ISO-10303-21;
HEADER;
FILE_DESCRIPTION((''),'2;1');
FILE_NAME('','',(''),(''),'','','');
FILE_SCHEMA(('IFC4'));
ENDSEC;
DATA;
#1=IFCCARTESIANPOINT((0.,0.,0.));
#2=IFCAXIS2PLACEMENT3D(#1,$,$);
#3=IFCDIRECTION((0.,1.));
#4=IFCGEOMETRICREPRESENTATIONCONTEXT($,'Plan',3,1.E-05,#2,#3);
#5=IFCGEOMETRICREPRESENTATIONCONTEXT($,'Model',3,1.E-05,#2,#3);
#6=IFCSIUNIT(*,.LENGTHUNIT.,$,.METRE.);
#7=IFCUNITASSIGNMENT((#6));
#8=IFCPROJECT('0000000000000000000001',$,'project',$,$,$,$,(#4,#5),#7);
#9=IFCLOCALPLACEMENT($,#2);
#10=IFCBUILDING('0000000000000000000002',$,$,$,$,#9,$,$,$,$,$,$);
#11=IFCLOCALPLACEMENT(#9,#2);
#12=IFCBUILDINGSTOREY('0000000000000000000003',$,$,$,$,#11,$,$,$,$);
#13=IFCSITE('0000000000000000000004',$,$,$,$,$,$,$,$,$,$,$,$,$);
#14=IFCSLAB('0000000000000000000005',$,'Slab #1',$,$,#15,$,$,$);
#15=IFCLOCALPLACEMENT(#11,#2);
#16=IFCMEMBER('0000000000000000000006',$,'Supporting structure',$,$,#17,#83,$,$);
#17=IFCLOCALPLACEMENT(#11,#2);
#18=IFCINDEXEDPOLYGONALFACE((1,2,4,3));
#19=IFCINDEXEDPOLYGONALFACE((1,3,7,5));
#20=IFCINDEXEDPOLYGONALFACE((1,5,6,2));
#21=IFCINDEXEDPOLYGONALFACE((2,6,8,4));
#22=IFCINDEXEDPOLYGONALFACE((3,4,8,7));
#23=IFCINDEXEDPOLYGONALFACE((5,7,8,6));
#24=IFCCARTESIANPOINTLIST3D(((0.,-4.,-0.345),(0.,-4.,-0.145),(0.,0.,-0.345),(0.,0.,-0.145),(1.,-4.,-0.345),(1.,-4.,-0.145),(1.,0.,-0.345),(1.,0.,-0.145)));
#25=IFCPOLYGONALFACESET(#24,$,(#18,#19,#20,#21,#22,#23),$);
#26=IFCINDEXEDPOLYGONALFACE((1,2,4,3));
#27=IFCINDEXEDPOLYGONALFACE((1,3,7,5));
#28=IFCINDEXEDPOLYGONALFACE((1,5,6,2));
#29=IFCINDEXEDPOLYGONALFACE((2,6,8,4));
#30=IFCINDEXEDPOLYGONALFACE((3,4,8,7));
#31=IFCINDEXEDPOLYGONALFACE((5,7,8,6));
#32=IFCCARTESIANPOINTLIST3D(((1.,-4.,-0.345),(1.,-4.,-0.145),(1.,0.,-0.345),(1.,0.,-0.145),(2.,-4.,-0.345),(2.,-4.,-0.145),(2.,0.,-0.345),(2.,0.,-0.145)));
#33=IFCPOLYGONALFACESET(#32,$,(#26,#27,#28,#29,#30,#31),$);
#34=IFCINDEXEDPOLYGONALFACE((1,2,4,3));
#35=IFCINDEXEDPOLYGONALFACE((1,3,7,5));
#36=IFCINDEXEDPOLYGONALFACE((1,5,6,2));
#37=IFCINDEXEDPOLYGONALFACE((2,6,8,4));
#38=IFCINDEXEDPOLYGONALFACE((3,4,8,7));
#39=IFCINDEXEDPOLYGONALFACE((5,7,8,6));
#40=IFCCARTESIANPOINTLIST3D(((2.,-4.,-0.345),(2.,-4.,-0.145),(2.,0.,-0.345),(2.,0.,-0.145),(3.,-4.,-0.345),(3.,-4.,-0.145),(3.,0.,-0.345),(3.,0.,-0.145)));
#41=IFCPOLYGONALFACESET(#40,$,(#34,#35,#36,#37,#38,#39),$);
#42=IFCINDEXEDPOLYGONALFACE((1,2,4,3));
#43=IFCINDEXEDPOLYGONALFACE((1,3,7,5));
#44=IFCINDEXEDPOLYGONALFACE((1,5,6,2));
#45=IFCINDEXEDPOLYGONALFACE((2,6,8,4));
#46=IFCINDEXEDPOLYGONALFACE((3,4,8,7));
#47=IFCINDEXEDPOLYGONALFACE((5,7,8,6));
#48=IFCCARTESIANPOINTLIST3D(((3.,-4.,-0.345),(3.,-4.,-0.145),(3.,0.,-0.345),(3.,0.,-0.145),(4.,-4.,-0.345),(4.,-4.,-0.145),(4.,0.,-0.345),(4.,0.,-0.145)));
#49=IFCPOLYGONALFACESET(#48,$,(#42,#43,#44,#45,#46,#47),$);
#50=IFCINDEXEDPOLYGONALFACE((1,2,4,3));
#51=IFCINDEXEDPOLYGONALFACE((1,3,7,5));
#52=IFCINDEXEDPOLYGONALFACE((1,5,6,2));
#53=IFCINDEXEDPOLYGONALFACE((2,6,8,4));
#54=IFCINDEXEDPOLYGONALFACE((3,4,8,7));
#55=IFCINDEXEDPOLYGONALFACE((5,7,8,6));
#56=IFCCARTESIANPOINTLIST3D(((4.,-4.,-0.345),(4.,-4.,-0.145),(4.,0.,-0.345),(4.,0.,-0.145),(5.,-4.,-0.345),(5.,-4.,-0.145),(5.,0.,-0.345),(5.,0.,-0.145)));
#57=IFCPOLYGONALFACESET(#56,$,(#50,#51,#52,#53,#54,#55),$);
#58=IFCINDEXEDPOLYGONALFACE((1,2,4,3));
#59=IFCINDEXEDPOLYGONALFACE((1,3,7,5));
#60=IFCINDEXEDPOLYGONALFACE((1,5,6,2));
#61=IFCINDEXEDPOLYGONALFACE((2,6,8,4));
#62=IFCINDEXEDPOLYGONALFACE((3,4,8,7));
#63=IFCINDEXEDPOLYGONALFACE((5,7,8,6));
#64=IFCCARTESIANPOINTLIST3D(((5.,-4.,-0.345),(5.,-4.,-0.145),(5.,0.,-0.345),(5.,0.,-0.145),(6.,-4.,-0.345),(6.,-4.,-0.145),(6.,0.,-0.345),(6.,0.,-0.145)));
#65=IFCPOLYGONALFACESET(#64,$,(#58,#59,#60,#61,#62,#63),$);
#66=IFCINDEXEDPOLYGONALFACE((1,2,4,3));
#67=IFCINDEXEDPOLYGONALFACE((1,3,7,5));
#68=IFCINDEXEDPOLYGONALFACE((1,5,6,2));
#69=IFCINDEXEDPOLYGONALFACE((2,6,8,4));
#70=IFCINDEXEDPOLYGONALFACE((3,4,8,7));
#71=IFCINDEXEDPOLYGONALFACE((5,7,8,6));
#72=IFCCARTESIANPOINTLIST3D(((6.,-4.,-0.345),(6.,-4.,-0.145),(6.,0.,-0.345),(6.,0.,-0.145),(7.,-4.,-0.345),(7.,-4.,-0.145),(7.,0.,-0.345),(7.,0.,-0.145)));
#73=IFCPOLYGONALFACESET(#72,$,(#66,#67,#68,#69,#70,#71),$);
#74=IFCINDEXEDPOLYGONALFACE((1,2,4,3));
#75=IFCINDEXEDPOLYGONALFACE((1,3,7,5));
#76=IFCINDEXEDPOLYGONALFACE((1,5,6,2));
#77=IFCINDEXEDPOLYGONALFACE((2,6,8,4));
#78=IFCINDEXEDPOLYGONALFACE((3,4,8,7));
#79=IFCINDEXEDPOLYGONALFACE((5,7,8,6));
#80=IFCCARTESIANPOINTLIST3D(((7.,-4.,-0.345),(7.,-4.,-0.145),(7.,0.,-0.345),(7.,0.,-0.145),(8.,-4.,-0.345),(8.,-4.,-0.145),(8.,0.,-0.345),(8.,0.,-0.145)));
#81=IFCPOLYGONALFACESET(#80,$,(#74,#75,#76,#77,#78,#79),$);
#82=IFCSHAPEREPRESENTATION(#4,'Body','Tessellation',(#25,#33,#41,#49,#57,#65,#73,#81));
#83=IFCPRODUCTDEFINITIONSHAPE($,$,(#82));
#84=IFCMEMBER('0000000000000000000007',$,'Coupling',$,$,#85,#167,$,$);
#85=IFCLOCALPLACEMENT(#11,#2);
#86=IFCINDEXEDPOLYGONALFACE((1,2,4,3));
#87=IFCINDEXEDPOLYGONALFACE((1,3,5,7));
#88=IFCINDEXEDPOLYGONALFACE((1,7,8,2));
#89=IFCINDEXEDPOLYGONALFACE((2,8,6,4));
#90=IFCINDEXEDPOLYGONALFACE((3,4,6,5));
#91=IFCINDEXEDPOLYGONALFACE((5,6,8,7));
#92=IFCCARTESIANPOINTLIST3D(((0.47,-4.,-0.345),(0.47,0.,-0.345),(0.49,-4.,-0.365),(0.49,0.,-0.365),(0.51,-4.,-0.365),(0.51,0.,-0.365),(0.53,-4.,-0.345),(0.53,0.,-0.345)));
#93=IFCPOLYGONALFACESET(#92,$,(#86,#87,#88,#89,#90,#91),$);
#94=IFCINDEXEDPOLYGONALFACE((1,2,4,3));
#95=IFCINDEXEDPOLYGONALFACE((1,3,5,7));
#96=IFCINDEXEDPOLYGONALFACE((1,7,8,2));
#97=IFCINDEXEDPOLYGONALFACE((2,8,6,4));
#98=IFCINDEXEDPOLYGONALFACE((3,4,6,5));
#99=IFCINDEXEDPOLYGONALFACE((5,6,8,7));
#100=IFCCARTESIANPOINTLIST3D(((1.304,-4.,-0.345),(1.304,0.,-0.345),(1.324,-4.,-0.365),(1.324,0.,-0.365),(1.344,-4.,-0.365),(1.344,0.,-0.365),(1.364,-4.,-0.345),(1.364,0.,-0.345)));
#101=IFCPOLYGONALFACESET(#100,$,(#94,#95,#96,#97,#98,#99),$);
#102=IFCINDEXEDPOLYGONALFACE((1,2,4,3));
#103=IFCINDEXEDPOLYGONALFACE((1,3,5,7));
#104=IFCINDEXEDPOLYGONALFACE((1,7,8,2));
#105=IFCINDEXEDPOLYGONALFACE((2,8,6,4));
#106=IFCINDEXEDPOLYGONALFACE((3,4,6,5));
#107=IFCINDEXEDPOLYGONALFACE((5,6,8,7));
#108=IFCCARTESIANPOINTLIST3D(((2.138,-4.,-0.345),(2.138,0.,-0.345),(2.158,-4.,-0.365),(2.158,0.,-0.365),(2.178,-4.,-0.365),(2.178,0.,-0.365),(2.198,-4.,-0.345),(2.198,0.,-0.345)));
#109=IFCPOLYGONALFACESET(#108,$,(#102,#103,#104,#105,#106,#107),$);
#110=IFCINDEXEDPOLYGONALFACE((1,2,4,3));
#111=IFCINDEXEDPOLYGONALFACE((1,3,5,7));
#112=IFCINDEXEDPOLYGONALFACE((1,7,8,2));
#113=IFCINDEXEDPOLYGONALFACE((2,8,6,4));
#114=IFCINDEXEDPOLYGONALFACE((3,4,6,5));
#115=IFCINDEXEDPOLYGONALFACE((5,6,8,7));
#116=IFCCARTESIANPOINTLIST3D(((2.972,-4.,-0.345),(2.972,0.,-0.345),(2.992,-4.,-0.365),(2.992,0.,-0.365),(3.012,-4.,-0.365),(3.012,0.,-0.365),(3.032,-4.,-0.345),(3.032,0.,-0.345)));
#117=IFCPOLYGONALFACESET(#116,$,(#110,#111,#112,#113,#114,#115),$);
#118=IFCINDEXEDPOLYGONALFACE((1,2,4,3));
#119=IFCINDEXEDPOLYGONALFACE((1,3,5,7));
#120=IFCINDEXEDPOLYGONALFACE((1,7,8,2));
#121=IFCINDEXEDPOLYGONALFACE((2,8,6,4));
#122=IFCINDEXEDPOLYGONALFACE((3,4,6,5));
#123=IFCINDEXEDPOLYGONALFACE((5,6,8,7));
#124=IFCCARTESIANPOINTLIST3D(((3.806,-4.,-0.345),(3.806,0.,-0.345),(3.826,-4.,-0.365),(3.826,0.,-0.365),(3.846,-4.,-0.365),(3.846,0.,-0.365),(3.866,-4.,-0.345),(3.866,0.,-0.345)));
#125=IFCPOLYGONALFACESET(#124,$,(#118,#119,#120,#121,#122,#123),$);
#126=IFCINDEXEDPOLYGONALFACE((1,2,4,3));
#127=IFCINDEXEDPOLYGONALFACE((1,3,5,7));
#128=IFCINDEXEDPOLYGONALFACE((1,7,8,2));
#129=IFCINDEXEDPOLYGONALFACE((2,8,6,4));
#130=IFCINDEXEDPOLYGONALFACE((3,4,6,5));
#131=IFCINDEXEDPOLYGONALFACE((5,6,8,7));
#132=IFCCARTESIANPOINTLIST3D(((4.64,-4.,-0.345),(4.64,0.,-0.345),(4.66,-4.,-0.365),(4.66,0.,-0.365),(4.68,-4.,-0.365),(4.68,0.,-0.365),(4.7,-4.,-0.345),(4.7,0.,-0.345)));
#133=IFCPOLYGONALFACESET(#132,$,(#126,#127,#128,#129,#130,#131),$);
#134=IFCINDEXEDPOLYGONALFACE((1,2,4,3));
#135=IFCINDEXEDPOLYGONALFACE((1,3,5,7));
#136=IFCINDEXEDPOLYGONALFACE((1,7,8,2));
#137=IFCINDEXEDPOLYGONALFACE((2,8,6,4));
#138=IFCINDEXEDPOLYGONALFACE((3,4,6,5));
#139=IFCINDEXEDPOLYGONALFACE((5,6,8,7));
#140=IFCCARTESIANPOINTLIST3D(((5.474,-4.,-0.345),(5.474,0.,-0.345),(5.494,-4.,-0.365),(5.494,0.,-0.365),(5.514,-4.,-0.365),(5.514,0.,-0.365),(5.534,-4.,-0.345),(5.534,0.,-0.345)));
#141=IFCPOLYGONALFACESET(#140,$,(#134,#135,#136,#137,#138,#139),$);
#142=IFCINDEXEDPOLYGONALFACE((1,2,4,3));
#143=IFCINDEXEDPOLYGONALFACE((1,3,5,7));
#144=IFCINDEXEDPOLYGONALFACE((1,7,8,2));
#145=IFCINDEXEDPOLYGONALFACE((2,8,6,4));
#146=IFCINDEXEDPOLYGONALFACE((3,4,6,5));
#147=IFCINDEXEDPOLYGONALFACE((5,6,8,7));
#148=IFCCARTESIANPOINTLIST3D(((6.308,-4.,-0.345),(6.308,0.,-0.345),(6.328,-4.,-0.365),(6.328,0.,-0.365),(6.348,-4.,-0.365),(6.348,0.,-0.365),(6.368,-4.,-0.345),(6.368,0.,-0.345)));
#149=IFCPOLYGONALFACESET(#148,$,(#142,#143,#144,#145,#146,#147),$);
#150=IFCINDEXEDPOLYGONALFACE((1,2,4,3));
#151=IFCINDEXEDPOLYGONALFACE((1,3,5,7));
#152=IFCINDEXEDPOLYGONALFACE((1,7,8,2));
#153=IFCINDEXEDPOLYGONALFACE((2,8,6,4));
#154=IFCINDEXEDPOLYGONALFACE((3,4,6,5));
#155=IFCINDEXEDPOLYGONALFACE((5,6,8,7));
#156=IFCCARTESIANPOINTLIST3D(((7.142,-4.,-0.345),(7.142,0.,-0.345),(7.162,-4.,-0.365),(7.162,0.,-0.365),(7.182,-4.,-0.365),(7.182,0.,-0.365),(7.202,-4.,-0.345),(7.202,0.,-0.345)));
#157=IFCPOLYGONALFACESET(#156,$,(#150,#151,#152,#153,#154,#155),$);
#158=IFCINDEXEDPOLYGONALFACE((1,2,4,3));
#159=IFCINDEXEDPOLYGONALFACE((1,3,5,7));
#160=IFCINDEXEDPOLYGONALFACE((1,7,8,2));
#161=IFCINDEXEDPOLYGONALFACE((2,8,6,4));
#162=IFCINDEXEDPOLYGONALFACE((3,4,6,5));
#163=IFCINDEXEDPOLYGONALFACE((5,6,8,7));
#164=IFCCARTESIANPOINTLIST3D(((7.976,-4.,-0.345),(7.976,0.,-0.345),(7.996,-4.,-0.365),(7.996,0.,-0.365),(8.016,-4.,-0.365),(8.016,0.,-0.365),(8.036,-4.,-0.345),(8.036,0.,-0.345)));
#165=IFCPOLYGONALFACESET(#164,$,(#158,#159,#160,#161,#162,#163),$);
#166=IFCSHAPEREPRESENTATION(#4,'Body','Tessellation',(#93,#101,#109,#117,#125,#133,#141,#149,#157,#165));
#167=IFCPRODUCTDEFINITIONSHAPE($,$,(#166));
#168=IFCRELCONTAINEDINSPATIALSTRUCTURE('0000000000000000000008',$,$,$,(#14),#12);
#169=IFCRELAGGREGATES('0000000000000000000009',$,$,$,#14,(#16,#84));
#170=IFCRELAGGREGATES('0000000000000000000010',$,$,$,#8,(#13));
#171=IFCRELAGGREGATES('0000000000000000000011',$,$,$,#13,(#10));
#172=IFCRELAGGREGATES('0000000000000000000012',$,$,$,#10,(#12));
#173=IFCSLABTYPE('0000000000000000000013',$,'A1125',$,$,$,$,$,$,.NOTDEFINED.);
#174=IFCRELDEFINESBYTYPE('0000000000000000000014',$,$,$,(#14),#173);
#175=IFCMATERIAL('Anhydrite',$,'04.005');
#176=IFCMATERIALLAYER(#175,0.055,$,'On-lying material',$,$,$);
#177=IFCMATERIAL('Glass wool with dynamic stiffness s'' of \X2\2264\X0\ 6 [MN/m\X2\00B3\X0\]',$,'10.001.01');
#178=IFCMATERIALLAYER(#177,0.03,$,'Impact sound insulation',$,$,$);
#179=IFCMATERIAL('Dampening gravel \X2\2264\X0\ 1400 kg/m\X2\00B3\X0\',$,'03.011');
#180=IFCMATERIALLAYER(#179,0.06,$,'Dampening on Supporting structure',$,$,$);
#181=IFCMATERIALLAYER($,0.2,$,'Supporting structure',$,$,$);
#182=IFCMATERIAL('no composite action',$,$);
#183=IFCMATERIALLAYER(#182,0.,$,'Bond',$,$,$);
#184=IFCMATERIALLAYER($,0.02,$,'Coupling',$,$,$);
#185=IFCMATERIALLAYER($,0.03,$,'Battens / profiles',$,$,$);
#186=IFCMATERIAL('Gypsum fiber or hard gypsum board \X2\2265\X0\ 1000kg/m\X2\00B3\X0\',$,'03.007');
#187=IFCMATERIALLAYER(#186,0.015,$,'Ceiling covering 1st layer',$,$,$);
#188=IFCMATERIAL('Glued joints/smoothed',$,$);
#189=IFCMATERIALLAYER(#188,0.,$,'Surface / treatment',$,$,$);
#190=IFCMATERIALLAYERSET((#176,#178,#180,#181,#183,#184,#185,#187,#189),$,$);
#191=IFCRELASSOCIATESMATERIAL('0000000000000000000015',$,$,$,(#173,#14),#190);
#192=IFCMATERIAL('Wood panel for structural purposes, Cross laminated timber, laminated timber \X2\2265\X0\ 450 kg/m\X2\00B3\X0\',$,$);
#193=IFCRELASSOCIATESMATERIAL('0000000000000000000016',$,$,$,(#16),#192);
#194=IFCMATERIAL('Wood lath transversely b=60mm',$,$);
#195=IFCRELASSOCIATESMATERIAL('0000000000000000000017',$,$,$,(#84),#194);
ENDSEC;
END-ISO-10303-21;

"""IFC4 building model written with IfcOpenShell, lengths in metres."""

from ifc_helpers import new_model, si_unit, direction, frame, frame_2d, origin, place, context, project, spatial, polyline, rectangle, outline, extrude, material, layer, layer_set, type_object, element, aggregate, save


model = new_model("IFC4")

# Units and contexts
plan_context = context("Plan", 3, precision=1e-05, world=origin(), true_north=direction((0.0, 1.0)))
model_context = context("Model", 3, precision=1e-05, world=origin(), true_north=direction((0.0, 1.0)))
ifc_project = project(units=[si_unit("LENGTHUNIT", "METRE")], contexts=[plan_context, model_context])

# Site, building, storey
site = spatial("IfcSite", under=ifc_project)
building_placement = place(None, origin())
building = spatial("IfcBuilding", under=site, at=building_placement)
storey_placement = place(building_placement, origin())
storey = spatial("IfcBuildingStorey", under=building, at=storey_placement)

# Slab, members
ifc_material_1 = material(Name="Anhydrite", Category="04.005")
ifc_layer_1 = layer(ifc_material_1, 0.055, Name="On-lying material")
ifc_material_2 = material(Name="Glass wool with dynamic stiffness s' of ≤ 6 [MN/m³]", Category="10.001.01")
ifc_layer_2 = layer(ifc_material_2, 0.03, Name="Impact sound insulation")
ifc_material_3 = material(Name="Dampening gravel ≤ 1400 kg/m³", Category="03.011")
ifc_layer_3 = layer(ifc_material_3, 0.06, Name="Dampening on Supporting structure")
ifc_layer_4 = layer(None, 0.2, Name="Supporting structure")
ifc_material_4 = material(Name="no composite action")
ifc_layer_5 = layer(ifc_material_4, 0.0, Name="Bond")
ifc_layer_6 = layer(None, 0.02, Name="Coupling")
ifc_layer_7 = layer(None, 0.03, Name="Battens / profiles")
ifc_material_5 = material(Name="Gypsum fiber or hard gypsum board ≥ 1000kg/m³", Category="03.007")
ifc_layer_8 = layer(ifc_material_5, 0.015, Name="Ceiling covering 1st layer")
ifc_material_6 = material(Name="Glued joints/smoothed")
ifc_layer_9 = layer(ifc_material_6, 0.0, Name="Surface / treatment")
ifc_layer_set = layer_set([ifc_layer_1, ifc_layer_2, ifc_layer_3, ifc_layer_4, ifc_layer_5, ifc_layer_6, ifc_layer_7, ifc_layer_8, ifc_layer_9])
slab_type = type_object("IfcSlabType", Name="A1125", PredefinedType="NOTDEFINED", material=ifc_layer_set)
slab_placement = place(None, frame((0.0, 0.0, 0.0), z_axis=(0.0, 0.0, -1.0), x_axis=(1.0, 0.0, 0.0)))
slab = element("IfcSlab", 1, at=slab_placement, inside=storey, type_object=slab_type, material=ifc_layer_set, Name="Slab #1")
ifc_material_7 = material(Name="Wood panel for structural purposes, Cross laminated timber, laminated timber ≥ 450 kg/m³")
member_1_placement = place(slab_placement, origin())
member_1 = element("IfcMember", 2, at=member_1_placement, material=ifc_material_7, Name="Supporting structure", context=plan_context, shape_type="SweptSolid", body=[
    extrude(rectangle(XDim=1.0, YDim=0.2, at=frame_2d((0.5, 0.1), x_axis=(1.0, 0.0))), frame((0.0, 4.0, 0.145), z_axis=(0.0, -1.0, 0.0), x_axis=(1.0, 0.0, 0.0)), (0.0, 0.0, 1.0), 4.0),
    extrude(rectangle(XDim=1.0, YDim=0.2, at=frame_2d((0.5, 0.1), x_axis=(1.0, 0.0))), frame((1.0, 4.0, 0.145), z_axis=(0.0, -1.0, 0.0), x_axis=(1.0, 0.0, 0.0)), (0.0, 0.0, 1.0), 4.0),
    extrude(rectangle(XDim=1.0, YDim=0.2, at=frame_2d((0.5, 0.1), x_axis=(1.0, 0.0))), frame((2.0, 4.0, 0.145), z_axis=(0.0, -1.0, 0.0), x_axis=(1.0, 0.0, 0.0)), (0.0, 0.0, 1.0), 4.0),
    extrude(rectangle(XDim=1.0, YDim=0.2, at=frame_2d((0.5, 0.1), x_axis=(1.0, 0.0))), frame((3.0, 4.0, 0.145), z_axis=(0.0, -1.0, 0.0), x_axis=(1.0, 0.0, 0.0)), (0.0, 0.0, 1.0), 4.0),
    extrude(rectangle(XDim=1.0, YDim=0.2, at=frame_2d((0.5, 0.1), x_axis=(1.0, 0.0))), frame((4.0, 4.0, 0.145), z_axis=(0.0, -1.0, 0.0), x_axis=(1.0, 0.0, 0.0)), (0.0, 0.0, 1.0), 4.0),
    extrude(rectangle(XDim=1.0, YDim=0.2, at=frame_2d((0.5, 0.1), x_axis=(1.0, 0.0))), frame((5.0, 4.0, 0.145), z_axis=(0.0, -1.0, 0.0), x_axis=(1.0, 0.0, 0.0)), (0.0, 0.0, 1.0), 4.0),
    extrude(rectangle(XDim=1.0, YDim=0.2, at=frame_2d((0.5, 0.1), x_axis=(1.0, 0.0))), frame((6.0, 4.0, 0.145), z_axis=(0.0, -1.0, 0.0), x_axis=(1.0, 0.0, 0.0)), (0.0, 0.0, 1.0), 4.0),
    extrude(rectangle(XDim=1.0, YDim=0.2, at=frame_2d((0.5, 0.1), x_axis=(1.0, 0.0))), frame((7.0, 4.0, 0.145), z_axis=(0.0, -1.0, 0.0), x_axis=(1.0, 0.0, 0.0)), (0.0, 0.0, 1.0), 4.0),
])
ifc_material_8 = material(Name="Wood lath transversely b=60mm")
member_2_placement = place(slab_placement, origin())
member_2 = element("IfcMember", 3, at=member_2_placement, material=ifc_material_8, Name="Coupling", context=plan_context, shape_type="SweptSolid", body=[
    extrude(outline(polyline([(0.0, 0.0), (0.06, 0.0), (0.04, 0.02), (0.02, 0.02), (0.0, 0.0)])), frame((0.47, 4.0, 0.345), z_axis=(0.0, -1.0, 0.0), x_axis=(1.0, 0.0, 0.0)), (0.0, 0.0, 1.0), 4.0),
    extrude(outline(polyline([(0.0, 0.0), (0.06, 0.0), (0.04, 0.02), (0.02, 0.02), (0.0, 0.0)])), frame((1.304, 4.0, 0.345), z_axis=(0.0, -1.0, 0.0), x_axis=(1.0, 0.0, 0.0)), (0.0, 0.0, 1.0), 4.0),
    extrude(outline(polyline([(0.0, 0.0), (0.06, 0.0), (0.04, 0.02), (0.02, 0.02), (0.0, 0.0)])), frame((2.138, 4.0, 0.345), z_axis=(0.0, -1.0, 0.0), x_axis=(1.0, 0.0, 0.0)), (0.0, 0.0, 1.0), 4.0),
    extrude(outline(polyline([(0.0, 0.0), (0.06, 0.0), (0.04, 0.02), (0.02, 0.02), (0.0, 0.0)])), frame((2.972, 4.0, 0.345), z_axis=(0.0, -1.0, 0.0), x_axis=(1.0, 0.0, 0.0)), (0.0, 0.0, 1.0), 4.0),
    extrude(outline(polyline([(0.0, 0.0), (0.06, 0.0), (0.04, 0.02), (0.02, 0.02), (0.0, 0.0)])), frame((3.806, 4.0, 0.345), z_axis=(0.0, -1.0, 0.0), x_axis=(1.0, 0.0, 0.0)), (0.0, 0.0, 1.0), 4.0),
    extrude(outline(polyline([(0.0, 0.0), (0.06, 0.0), (0.04, 0.02), (0.02, 0.02), (0.0, 0.0)])), frame((4.64, 4.0, 0.345), z_axis=(0.0, -1.0, 0.0), x_axis=(1.0, 0.0, 0.0)), (0.0, 0.0, 1.0), 4.0),
    extrude(outline(polyline([(0.0, 0.0), (0.06, 0.0), (0.04, 0.02), (0.02, 0.02), (0.0, 0.0)])), frame((5.474, 4.0, 0.345), z_axis=(0.0, -1.0, 0.0), x_axis=(1.0, 0.0, 0.0)), (0.0, 0.0, 1.0), 4.0),
    extrude(outline(polyline([(0.0, 0.0), (0.06, 0.0), (0.04, 0.02), (0.02, 0.02), (0.0, 0.0)])), frame((6.308, 4.0, 0.345), z_axis=(0.0, -1.0, 0.0), x_axis=(1.0, 0.0, 0.0)), (0.0, 0.0, 1.0), 4.0),
    extrude(outline(polyline([(0.0, 0.0), (0.06, 0.0), (0.04, 0.02), (0.02, 0.02), (0.0, 0.0)])), frame((7.142, 4.0, 0.345), z_axis=(0.0, -1.0, 0.0), x_axis=(1.0, 0.0, 0.0)), (0.0, 0.0, 1.0), 4.0),
    extrude(outline(polyline([(0.0, 0.0), (0.06, 0.0), (0.04, 0.02), (0.02, 0.02), (0.0, 0.0)])), frame((7.976, 4.0, 0.345), z_axis=(0.0, -1.0, 0.0), x_axis=(1.0, 0.0, 0.0)), (0.0, 0.0, 1.0), 4.0),
])
aggregate(slab, [member_1, member_2])

save(model, "model.ifc")
